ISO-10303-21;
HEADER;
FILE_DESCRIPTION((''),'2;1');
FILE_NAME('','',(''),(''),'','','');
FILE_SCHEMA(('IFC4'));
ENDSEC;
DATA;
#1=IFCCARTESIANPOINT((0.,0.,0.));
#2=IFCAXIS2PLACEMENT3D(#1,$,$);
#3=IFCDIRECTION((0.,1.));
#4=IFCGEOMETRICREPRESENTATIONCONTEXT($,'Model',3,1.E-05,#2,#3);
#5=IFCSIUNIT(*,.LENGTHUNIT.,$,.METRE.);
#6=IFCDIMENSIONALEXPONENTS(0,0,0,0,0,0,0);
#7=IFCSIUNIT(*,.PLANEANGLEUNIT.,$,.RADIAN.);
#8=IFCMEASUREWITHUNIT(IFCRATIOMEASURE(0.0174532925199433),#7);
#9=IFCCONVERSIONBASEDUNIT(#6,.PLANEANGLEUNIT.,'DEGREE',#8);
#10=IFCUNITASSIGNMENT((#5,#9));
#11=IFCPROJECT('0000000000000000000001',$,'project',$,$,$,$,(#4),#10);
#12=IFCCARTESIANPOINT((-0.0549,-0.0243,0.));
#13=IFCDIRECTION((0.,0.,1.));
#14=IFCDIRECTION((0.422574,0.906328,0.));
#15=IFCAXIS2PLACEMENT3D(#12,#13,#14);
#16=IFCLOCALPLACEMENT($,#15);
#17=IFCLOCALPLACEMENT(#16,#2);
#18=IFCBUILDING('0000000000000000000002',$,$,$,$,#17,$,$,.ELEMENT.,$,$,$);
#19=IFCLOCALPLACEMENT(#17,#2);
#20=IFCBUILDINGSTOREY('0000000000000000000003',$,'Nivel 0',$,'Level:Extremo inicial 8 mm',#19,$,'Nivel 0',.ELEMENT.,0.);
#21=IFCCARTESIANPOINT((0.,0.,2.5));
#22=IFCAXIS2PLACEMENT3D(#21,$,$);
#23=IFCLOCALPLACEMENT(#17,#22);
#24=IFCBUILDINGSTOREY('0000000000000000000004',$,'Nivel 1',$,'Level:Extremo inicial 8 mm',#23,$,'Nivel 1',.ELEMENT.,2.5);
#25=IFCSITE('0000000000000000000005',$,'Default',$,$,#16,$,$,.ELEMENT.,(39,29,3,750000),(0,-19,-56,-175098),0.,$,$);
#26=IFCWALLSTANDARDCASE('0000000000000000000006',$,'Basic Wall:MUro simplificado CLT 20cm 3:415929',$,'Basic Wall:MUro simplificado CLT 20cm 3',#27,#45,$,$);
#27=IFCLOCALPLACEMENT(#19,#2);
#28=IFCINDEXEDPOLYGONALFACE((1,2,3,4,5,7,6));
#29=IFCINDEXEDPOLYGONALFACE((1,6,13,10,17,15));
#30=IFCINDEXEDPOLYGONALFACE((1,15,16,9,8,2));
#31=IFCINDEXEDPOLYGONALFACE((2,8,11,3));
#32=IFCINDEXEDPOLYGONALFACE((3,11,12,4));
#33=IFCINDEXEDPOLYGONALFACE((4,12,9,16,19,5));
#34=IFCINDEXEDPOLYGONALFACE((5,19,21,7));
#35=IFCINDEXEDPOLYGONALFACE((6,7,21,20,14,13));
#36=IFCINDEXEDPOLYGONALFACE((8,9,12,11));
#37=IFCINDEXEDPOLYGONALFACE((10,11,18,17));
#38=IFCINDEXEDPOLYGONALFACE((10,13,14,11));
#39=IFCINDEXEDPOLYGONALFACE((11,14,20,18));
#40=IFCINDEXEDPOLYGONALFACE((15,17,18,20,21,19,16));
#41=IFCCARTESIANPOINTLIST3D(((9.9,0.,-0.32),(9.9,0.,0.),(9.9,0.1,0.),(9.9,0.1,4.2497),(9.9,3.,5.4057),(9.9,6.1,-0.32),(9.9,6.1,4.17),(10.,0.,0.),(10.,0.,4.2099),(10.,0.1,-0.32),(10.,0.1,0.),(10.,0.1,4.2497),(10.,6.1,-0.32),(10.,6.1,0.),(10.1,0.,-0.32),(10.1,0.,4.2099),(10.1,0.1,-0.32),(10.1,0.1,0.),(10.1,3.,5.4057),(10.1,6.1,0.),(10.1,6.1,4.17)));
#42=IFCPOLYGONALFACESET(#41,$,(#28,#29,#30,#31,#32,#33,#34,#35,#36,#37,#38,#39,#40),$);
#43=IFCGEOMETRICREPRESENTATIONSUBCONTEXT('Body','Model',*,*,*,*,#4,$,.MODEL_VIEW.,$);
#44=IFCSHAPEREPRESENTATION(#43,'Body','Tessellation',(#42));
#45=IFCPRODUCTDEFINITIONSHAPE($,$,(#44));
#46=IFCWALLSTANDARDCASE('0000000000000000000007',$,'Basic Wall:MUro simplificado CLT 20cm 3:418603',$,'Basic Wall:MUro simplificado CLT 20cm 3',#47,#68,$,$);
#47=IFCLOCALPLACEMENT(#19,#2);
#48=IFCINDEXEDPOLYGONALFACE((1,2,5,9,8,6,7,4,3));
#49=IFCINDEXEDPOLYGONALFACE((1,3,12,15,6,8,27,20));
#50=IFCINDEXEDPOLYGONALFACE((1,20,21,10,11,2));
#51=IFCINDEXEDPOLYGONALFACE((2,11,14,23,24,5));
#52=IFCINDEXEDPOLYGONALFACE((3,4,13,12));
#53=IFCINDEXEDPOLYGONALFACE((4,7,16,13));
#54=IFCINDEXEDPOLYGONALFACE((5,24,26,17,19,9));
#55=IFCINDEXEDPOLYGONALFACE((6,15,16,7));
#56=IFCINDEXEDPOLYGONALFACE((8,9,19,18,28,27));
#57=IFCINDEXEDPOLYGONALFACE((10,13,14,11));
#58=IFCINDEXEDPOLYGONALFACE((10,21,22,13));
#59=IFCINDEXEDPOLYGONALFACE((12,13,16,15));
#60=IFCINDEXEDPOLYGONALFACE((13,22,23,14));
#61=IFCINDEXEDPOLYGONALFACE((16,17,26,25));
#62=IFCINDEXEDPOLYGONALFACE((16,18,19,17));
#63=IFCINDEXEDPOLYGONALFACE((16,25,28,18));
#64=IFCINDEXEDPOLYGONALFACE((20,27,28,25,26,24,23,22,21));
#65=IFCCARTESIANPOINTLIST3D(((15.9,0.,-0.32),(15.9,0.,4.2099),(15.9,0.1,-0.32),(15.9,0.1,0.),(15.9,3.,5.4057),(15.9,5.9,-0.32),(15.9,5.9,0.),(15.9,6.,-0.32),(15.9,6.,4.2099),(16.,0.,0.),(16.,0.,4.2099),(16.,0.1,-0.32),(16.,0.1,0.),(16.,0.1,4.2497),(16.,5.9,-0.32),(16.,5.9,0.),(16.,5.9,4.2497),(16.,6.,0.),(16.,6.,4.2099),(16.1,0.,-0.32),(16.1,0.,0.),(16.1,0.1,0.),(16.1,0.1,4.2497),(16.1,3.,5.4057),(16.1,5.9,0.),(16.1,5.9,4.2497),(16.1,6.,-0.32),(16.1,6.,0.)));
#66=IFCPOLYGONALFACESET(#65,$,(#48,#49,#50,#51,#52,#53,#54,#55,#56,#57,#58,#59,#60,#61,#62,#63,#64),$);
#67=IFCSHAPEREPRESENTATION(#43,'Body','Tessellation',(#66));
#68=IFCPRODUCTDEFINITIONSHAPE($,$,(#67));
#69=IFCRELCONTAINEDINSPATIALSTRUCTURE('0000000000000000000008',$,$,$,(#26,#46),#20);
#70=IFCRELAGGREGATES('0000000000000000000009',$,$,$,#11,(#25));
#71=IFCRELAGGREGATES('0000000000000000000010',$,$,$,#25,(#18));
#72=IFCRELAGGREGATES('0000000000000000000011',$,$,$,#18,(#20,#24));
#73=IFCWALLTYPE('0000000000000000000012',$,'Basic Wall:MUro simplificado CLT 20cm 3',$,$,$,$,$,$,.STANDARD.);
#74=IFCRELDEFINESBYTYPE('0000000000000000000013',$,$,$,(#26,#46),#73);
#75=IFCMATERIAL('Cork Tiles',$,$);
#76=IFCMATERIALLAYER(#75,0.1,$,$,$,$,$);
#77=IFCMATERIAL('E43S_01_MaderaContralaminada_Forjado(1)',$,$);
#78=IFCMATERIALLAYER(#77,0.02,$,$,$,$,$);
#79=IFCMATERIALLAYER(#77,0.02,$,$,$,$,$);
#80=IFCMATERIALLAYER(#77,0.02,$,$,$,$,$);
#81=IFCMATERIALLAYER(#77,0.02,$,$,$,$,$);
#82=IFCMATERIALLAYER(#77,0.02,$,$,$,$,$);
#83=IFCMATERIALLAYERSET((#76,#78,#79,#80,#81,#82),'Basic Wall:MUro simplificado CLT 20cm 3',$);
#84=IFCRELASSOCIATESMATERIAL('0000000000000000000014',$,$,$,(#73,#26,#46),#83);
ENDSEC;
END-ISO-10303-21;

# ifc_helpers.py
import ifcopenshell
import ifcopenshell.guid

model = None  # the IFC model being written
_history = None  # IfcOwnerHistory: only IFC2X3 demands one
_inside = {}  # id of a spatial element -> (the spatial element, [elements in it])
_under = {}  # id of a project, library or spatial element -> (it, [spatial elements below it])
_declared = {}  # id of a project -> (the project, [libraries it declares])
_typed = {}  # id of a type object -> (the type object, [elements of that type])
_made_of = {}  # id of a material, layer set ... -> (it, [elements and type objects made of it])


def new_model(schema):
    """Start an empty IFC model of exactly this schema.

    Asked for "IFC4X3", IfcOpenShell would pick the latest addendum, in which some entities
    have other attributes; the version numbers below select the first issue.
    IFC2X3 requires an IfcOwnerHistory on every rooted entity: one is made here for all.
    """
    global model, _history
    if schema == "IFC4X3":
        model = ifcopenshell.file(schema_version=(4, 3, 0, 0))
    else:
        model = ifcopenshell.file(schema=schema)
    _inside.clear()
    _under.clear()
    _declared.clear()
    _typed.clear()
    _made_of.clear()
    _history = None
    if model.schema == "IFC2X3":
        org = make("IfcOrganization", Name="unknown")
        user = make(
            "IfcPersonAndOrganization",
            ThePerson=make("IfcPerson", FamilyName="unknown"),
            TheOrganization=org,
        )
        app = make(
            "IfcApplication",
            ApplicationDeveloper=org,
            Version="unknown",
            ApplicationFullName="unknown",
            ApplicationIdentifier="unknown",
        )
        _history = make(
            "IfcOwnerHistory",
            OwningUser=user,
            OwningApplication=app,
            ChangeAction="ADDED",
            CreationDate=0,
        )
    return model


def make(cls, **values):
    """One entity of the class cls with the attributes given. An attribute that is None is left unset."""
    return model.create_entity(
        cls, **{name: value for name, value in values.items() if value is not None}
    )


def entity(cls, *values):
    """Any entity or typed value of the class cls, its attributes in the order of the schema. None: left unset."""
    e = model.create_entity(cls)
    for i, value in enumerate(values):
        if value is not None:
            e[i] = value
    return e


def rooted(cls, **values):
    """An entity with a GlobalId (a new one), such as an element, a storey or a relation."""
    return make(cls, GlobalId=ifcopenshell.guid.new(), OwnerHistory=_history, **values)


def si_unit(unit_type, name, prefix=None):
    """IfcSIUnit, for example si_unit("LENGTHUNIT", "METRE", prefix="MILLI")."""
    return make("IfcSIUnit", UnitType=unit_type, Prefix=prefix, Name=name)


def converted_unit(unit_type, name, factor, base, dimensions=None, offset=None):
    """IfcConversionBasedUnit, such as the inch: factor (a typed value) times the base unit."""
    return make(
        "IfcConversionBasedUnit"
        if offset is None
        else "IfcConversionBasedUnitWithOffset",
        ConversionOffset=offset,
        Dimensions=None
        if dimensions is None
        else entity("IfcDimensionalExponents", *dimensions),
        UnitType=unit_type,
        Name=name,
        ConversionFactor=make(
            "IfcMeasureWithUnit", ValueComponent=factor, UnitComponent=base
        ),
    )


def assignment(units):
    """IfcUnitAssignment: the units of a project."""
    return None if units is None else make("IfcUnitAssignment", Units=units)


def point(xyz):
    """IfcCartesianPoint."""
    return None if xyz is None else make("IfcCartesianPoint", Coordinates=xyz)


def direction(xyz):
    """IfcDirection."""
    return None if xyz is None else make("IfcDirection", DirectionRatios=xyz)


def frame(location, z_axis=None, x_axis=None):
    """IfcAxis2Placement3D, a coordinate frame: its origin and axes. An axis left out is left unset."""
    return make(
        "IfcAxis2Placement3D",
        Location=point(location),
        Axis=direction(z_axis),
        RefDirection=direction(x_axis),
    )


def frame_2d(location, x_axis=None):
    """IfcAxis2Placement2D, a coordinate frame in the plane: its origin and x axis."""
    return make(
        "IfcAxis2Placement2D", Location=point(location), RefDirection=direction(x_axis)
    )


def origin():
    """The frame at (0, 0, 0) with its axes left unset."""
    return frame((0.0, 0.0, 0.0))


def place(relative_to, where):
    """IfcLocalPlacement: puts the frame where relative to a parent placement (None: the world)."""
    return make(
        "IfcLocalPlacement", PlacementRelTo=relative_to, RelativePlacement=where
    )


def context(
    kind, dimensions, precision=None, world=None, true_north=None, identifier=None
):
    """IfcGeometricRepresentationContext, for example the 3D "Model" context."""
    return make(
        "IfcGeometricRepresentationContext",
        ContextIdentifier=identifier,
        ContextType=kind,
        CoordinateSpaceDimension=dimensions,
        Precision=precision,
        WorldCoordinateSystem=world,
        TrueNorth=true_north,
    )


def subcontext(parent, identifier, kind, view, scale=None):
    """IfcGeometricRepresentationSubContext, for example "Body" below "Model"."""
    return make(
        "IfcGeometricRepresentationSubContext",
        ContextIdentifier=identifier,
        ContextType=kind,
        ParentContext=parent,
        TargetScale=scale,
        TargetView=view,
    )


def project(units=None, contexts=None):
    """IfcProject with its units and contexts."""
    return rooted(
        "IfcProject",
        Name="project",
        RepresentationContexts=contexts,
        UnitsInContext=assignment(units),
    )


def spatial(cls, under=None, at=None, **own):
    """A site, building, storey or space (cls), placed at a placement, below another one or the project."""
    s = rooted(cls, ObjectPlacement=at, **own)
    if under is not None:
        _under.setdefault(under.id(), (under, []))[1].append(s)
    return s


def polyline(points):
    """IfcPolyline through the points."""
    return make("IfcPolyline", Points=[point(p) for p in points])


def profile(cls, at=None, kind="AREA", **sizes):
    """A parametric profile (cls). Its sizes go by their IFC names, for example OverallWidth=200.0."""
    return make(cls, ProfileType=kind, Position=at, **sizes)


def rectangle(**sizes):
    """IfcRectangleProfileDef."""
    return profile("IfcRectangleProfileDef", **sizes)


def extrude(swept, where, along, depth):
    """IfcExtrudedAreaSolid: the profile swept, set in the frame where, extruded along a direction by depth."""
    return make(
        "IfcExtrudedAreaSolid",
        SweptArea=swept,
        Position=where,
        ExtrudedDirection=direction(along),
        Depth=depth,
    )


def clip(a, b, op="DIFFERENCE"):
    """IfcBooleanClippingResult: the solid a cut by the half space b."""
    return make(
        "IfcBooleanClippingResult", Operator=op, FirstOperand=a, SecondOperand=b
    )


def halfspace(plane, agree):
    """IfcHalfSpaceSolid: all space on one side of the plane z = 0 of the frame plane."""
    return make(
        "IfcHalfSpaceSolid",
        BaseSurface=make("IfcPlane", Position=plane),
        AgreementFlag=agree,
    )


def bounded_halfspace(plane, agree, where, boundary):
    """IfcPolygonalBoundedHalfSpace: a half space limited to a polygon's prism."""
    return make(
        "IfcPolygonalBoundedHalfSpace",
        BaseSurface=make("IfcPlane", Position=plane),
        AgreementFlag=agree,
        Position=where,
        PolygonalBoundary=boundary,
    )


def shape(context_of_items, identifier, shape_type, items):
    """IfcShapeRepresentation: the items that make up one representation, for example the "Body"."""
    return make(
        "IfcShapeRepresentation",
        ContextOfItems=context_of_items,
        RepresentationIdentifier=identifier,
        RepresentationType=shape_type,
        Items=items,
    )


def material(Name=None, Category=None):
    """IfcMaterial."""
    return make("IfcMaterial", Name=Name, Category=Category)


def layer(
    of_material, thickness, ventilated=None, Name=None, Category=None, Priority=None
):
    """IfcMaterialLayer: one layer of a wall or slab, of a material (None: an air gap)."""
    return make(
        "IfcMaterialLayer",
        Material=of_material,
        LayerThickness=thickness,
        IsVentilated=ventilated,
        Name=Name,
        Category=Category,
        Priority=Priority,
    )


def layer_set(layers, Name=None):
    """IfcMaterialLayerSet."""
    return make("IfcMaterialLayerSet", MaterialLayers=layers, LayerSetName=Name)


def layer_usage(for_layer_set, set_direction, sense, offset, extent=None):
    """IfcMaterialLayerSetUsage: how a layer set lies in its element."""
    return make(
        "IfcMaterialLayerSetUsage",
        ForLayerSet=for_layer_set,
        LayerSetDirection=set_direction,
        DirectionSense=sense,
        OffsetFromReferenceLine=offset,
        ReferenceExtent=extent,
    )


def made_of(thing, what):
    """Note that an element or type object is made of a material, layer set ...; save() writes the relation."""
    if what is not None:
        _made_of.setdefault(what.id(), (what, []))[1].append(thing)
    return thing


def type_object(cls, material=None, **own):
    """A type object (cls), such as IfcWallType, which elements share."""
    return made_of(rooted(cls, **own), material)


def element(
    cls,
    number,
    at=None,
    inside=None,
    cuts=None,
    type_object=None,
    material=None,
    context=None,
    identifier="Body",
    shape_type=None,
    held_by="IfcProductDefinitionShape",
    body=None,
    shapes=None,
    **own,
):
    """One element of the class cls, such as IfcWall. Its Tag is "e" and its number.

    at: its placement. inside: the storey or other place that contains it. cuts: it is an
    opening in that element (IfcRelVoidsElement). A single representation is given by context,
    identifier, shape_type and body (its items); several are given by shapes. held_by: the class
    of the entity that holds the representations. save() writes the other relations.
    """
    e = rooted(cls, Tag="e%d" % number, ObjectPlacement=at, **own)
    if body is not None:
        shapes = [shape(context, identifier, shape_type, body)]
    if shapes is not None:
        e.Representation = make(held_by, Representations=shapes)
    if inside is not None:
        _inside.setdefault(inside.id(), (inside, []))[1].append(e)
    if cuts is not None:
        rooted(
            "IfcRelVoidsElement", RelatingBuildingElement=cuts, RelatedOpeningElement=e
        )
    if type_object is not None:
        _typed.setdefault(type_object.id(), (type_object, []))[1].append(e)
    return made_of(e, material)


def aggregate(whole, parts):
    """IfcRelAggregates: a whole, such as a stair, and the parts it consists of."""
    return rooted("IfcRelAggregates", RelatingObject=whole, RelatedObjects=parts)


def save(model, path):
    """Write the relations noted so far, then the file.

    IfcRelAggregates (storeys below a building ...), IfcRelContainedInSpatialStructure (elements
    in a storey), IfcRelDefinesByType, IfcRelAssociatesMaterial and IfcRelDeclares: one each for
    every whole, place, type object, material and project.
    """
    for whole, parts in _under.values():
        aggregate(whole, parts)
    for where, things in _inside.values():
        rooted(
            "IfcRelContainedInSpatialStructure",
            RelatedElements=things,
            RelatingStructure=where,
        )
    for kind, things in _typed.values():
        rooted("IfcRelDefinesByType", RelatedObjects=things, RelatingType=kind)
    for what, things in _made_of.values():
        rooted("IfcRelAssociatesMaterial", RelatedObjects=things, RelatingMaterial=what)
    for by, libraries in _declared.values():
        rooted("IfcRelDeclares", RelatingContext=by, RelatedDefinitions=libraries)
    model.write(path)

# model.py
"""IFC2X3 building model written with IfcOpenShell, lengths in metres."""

from ifc_helpers import new_model, entity, si_unit, converted_unit, direction, frame, frame_2d, origin, place, context, subcontext, project, spatial, polyline, rectangle, extrude, clip, halfspace, bounded_halfspace, material, layer, layer_set, layer_usage, type_object, element, save


model = new_model("IFC2X3")

# Units and contexts
model_context = context("Model", 3, precision=1e-05, world=origin(), true_north=direction((0.0, 1.0)))
body_context = subcontext(model_context, "Body", "Model", "MODEL_VIEW")
ifc_project = project(units=[si_unit("LENGTHUNIT", "METRE"), converted_unit("PLANEANGLEUNIT", "DEGREE", entity("IfcRatioMeasure", 0.0174532925199433), si_unit("PLANEANGLEUNIT", "RADIAN"), dimensions=[0, 0, 0, 0, 0, 0, 0])], contexts=[model_context])

# Site, building, storey
site_placement = place(None, frame((-0.0549, -0.0243, 0.0), z_axis=(0.0, 0.0, 1.0), x_axis=(0.422574, 0.906328, 0.0)))
site = spatial("IfcSite", under=ifc_project, at=site_placement, Name="Default", CompositionType="ELEMENT", RefLatitude=(39, 29, 3, 750000), RefLongitude=(0, -19, -56, -175098), RefElevation=0.0)
building_placement = place(site_placement, origin())
building = spatial("IfcBuilding", under=site, at=building_placement, CompositionType="ELEMENT")
storey_1_placement = place(building_placement, origin())
storey_1 = spatial("IfcBuildingStorey", under=building, at=storey_1_placement, Name="Nivel 0", ObjectType="Level:Extremo inicial 8 mm", LongName="Nivel 0", CompositionType="ELEMENT", Elevation=0.0)

# Shared definitions
ifc_material_1 = material(Name="Cork Tiles")

# Shared definitions
ifc_layer_1 = layer(ifc_material_1, 0.1)
ifc_material_2 = material(Name="E43S_01_MaderaContralaminada_Forjado(1)")
ifc_layer_2 = layer(ifc_material_2, 0.02)
ifc_layer_3 = layer(ifc_material_2, 0.02)
ifc_layer_4 = layer(ifc_material_2, 0.02)
ifc_layer_5 = layer(ifc_material_2, 0.02)
ifc_layer_6 = layer(ifc_material_2, 0.02)
ifc_layer_set_1 = layer_set([ifc_layer_1, ifc_layer_2, ifc_layer_3, ifc_layer_4, ifc_layer_5, ifc_layer_6], Name="Basic Wall:MUro simplificado CLT 20cm 3")
wall_type = type_object("IfcWallType", Name="Basic Wall:MUro simplificado CLT 20cm 3", PredefinedType="STANDARD", material=ifc_layer_set_1)

# Shared definitions
storey_2_placement = place(building_placement, frame((0.0, 0.0, 2.5)))
storey_2 = spatial("IfcBuildingStorey", under=building, at=storey_2_placement, Name="Nivel 1", ObjectType="Level:Extremo inicial 8 mm", LongName="Nivel 1", CompositionType="ELEMENT", Elevation=2.5)

# Walls
ifc_layer_usage_1 = layer_usage(ifc_layer_set_1, "AXIS2", "NEGATIVE", 0.1)
wall_1_placement = place(storey_1_placement, frame((10.0, 0.0, -0.32), z_axis=(0.0, 0.0, 1.0), x_axis=(0.0, 1.0, 0.0)))
element("IfcWallStandardCase", 1, at=wall_1_placement, inside=storey_1, type_object=wall_type, material=ifc_layer_usage_1, Name="Basic Wall:MUro simplificado CLT 20cm 3:415929", ObjectType="Basic Wall:MUro simplificado CLT 20cm 3", context=body_context, shape_type="Clipping", body=[
    clip(clip(clip(clip(extrude(rectangle(XDim=6.1, YDim=0.2, at=frame_2d((3.05, 0.0), x_axis=(-1.0, 0.0))), origin(), (0.0, 0.0, 1.0), 5.7257), bounded_halfspace(frame((6.1, -0.1, 0.32), z_axis=(0.0, 0.0, -1.0), x_axis=(0.0, 1.0, 0.0)), False, frame((6.1, -0.1, 0.32)), polyline([(0.0, 0.0), (0.0, 0.1), (-0.1, 0.1), (-6.0, 0.1), (-6.0, 0.0), (-0.2, 0.0), (0.0, 0.0)]))), bounded_halfspace(frame((0.0, 0.0, 0.32)), False, frame((0.0, 0.0, 0.32)), polyline([(0.0, 0.0), (0.1, 0.0), (0.1, 0.1), (0.0, 0.1), (0.0, 0.0)]))), halfspace(frame((3.0, -0.1, 5.7257), z_axis=(0.370288, 0.0, 0.928917), x_axis=(0.0, 1.0, 0.0)), False)), halfspace(frame((0.1, -0.1, 4.5697), z_axis=(-0.370288, 0.0, 0.928917), x_axis=(0.0, 1.0, 0.0)), False)),
])
ifc_layer_usage_2 = layer_usage(ifc_layer_set_1, "AXIS2", "NEGATIVE", 0.1)
wall_2_placement = place(storey_1_placement, frame((16.0, 6.0, -0.32), z_axis=(0.0, 0.0, 1.0), x_axis=(0.0, -1.0, 0.0)))
element("IfcWallStandardCase", 2, at=wall_2_placement, inside=storey_1, type_object=wall_type, material=ifc_layer_usage_2, Name="Basic Wall:MUro simplificado CLT 20cm 3:418603", ObjectType="Basic Wall:MUro simplificado CLT 20cm 3", context=body_context, shape_type="Clipping", body=[
    clip(clip(clip(clip(clip(extrude(rectangle(XDim=6.0, YDim=0.2, at=frame_2d((3.0, 0.0), x_axis=(-1.0, 0.0))), origin(), (0.0, 0.0, 1.0), 5.7257), bounded_halfspace(frame((5.9, -0.1, 0.32), z_axis=(0.0, 0.0, -1.0), x_axis=(0.0, 1.0, 0.0)), False, frame((5.9, -0.1, 0.32)), polyline([(0.0, 0.0), (0.0, 0.1), (-5.8, 0.1), (-5.8, 0.0), (0.0, 0.0)]))), bounded_halfspace(frame((0.0, 0.0, 0.32)), False, frame((0.0, 0.0, 0.32)), polyline([(0.0, 0.0), (0.1, 0.0), (0.1, 0.1), (0.0, 0.1), (0.0, 0.0)]))), bounded_halfspace(frame((6.0, 0.1, 0.32), z_axis=(0.0, 0.0, 1.0), x_axis=(-1.0, 0.0, 0.0)), False, frame((6.0, 0.1, 0.32)), polyline([(0.0, 0.0), (-0.1, 0.0), (-0.1, -0.1), (0.0, -0.1), (0.0, 0.0)]))), halfspace(frame((3.0, -0.1, 5.7257), z_axis=(0.370288, 0.0, 0.928917), x_axis=(0.0, 1.0, 0.0)), False)), halfspace(frame((0.1, -0.1, 4.5697), z_axis=(-0.370288, 0.0, 0.928917), x_axis=(0.0, 1.0, 0.0)), False)),
])

save(model, "model.ifc")
